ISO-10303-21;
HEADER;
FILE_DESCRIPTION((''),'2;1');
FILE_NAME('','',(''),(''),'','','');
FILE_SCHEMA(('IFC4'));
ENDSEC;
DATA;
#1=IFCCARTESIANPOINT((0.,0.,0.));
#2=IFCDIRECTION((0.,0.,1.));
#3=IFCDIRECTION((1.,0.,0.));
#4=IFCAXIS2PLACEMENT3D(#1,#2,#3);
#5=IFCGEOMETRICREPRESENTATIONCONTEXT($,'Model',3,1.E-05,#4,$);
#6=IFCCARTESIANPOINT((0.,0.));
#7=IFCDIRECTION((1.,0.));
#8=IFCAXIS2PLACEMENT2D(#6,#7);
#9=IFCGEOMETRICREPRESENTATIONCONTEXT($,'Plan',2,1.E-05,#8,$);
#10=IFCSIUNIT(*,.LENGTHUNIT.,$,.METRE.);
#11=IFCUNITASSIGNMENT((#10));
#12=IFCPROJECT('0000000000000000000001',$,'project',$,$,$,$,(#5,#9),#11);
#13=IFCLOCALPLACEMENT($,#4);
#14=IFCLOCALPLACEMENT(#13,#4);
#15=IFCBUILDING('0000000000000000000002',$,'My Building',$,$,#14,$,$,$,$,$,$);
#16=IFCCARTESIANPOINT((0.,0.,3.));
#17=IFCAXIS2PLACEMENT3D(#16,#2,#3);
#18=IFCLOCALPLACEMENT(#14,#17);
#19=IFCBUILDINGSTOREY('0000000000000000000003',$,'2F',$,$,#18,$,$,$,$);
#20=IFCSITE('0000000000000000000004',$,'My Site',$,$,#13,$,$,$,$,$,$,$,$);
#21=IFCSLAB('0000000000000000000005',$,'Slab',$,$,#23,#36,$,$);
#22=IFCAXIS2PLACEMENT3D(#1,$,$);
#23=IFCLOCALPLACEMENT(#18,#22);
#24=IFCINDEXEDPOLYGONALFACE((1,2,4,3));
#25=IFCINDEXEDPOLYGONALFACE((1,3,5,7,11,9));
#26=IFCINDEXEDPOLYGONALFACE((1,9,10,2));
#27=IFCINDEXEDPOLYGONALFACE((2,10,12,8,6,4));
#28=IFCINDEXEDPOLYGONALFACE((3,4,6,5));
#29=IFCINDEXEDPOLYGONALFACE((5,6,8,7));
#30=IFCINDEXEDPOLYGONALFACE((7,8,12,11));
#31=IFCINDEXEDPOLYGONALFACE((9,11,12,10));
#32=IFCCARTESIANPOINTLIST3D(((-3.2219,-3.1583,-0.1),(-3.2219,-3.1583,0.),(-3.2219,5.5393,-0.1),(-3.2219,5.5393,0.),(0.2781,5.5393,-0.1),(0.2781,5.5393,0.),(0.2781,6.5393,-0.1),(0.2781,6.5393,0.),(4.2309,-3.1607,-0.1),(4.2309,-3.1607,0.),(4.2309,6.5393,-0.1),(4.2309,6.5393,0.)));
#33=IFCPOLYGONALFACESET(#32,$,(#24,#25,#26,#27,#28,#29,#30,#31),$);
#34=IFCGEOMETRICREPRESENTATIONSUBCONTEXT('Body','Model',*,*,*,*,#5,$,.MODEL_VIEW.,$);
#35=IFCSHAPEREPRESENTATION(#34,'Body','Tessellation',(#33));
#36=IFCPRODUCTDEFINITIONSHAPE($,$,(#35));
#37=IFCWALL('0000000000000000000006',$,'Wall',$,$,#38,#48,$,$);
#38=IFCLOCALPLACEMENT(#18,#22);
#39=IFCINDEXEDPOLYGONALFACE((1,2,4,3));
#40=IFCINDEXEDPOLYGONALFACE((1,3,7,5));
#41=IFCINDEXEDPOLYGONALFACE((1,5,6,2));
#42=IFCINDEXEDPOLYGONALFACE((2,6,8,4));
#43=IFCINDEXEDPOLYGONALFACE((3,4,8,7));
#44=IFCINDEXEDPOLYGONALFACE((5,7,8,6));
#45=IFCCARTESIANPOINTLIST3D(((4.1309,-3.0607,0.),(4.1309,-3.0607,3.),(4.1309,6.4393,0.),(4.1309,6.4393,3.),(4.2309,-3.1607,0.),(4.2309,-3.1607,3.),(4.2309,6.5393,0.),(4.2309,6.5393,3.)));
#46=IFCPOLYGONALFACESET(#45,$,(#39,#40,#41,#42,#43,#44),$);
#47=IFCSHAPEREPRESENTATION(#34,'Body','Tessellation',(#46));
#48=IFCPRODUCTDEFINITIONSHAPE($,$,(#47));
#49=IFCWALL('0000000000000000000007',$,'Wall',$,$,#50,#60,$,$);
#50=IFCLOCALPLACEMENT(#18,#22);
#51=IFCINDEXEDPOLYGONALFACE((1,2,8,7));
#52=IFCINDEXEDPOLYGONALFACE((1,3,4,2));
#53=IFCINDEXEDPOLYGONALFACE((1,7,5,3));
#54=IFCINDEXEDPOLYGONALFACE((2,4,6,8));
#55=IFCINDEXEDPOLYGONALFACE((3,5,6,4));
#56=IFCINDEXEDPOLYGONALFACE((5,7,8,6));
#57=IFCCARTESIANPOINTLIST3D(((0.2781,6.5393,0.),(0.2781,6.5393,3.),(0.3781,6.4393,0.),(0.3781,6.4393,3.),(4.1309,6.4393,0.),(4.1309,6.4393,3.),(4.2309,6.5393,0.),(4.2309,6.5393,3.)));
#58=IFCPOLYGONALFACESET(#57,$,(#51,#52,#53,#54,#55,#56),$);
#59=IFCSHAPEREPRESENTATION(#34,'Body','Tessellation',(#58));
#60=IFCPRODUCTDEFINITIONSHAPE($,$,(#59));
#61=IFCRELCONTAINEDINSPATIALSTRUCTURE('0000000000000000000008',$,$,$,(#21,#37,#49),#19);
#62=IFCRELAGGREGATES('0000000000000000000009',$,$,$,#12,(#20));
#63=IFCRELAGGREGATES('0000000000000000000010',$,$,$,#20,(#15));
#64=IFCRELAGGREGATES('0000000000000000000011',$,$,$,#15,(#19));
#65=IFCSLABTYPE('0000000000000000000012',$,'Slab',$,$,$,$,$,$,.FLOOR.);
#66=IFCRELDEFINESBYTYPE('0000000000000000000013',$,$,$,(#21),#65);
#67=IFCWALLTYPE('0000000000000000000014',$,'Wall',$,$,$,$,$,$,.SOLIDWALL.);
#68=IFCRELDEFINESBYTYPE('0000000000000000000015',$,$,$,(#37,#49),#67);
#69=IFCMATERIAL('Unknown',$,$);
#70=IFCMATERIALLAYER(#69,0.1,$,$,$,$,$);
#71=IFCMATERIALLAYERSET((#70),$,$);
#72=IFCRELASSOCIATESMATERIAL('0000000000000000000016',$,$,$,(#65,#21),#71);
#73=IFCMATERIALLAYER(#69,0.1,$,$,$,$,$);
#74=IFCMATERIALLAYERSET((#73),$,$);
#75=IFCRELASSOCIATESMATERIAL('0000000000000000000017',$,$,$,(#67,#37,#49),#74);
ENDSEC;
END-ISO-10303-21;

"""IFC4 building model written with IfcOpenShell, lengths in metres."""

from ifc_helpers import new_model, si_unit, frame, origin_with_axes, origin_2d_with_axis, place, context, subcontext, project, spatial, line, indexed_curve, outline, extrude, material, layer, layer_set, layer_usage, type_object, element, save


model = new_model("IFC4")

# Units and contexts
model_context = context("Model", 3, precision=1e-05, world=origin_with_axes())
plan_context = context("Plan", 2, precision=1e-05, world=origin_2d_with_axis())
body_context_1 = subcontext(model_context, "Body", "Model", "MODEL_VIEW")
ifc_project = project(units=[si_unit("LENGTHUNIT", "METRE")], contexts=[model_context, plan_context])

# Site, building, storey
site_placement = place(None, origin_with_axes())
site = spatial("IfcSite", under=ifc_project, at=site_placement, Name="My Site")
building_placement = place(site_placement, origin_with_axes())
building = spatial("IfcBuilding", under=site, at=building_placement, Name="My Building")
storey_placement = place(building_placement, frame((0.0, 0.0, 3.0), z_axis=(0.0, 0.0, 1.0), x_axis=(1.0, 0.0, 0.0)))
storey = spatial("IfcBuildingStorey", under=building, at=storey_placement, Name="2F")

# Slab
ifc_material = material(Name="Unknown")
ifc_layer_1 = layer(ifc_material, 0.1)
ifc_layer_set_1 = layer_set([ifc_layer_1])
ifc_layer_usage_1 = layer_usage(ifc_layer_set_1, "AXIS3", "POSITIVE", -0.1)
slab_type = type_object("IfcSlabType", Name="Slab", PredefinedType="FLOOR", material=ifc_layer_set_1)
slab_placement = place(storey_placement, frame((-3.2219, -3.1583, 0.0), z_axis=(0.0, 0.0, 1.0), x_axis=(1.0, 0.0, 0.0)))
element("IfcSlab", 1, at=slab_placement, inside=storey, type_object=slab_type, material=ifc_layer_usage_1, Name="Slab", context=body_context_1, shape_type="SweptSolid", body=[
    extrude(outline(indexed_curve([(0.0, 0.0), (0.0, 8.6976), (3.5, 8.6976), (3.5, 9.6976), (7.4528, 9.6976), (7.4528, -0.0024), (0.0, 0.0)])), frame((0.0, 0.0, -0.1), z_axis=(0.0, 0.0, 1.0), x_axis=(1.0, 0.0, 0.0)), (0.0, 0.0, 1.0), 0.1),
])

# Walls
ifc_layer_2 = layer(ifc_material, 0.1)
ifc_layer_set_2 = layer_set([ifc_layer_2])
ifc_layer_usage_2 = layer_usage(ifc_layer_set_2, "AXIS2", "POSITIVE", 0.0)
wall_type = type_object("IfcWallType", Name="Wall", PredefinedType="SOLIDWALL", material=ifc_layer_set_2)
wall_1_placement = place(storey_placement, frame((4.2309, -3.1607, 0.0), z_axis=(0.0, 0.0, 1.0), x_axis=(0.0, 1.0, 0.0)))
element("IfcWall", 2, at=wall_1_placement, inside=storey, type_object=wall_type, material=ifc_layer_usage_2, Name="Wall", context=body_context_1, shape_type="SweptSolid", body=[
    extrude(outline(indexed_curve([(0.0, 0.0), (0.1, 0.1), (9.6, 0.1), (9.7, 0.0)], segments=[line(1, 2, 3, 4, 1)])), origin_with_axes(), (0.0, 0.0, 1.0), 3.0),
])
ifc_layer_usage_3 = layer_usage(ifc_layer_set_2, "AXIS2", "POSITIVE", 0.0)
wall_2_placement = place(storey_placement, frame((4.2309, 6.5393, 0.0), z_axis=(0.0, 0.0, 1.0), x_axis=(-1.0, 0.0, 0.0)))
element("IfcWall", 3, at=wall_2_placement, inside=storey, type_object=wall_type, material=ifc_layer_usage_3, Name="Wall", context=body_context_1, shape_type="SweptSolid", body=[
    extrude(outline(indexed_curve([(0.0, 0.0), (0.1, 0.1), (3.8528, 0.1), (3.9528, 0.0)], segments=[line(1, 2, 3, 4, 1)])), origin_with_axes(), (0.0, 0.0, 1.0), 3.0),
])

save(model, "model.ifc")
